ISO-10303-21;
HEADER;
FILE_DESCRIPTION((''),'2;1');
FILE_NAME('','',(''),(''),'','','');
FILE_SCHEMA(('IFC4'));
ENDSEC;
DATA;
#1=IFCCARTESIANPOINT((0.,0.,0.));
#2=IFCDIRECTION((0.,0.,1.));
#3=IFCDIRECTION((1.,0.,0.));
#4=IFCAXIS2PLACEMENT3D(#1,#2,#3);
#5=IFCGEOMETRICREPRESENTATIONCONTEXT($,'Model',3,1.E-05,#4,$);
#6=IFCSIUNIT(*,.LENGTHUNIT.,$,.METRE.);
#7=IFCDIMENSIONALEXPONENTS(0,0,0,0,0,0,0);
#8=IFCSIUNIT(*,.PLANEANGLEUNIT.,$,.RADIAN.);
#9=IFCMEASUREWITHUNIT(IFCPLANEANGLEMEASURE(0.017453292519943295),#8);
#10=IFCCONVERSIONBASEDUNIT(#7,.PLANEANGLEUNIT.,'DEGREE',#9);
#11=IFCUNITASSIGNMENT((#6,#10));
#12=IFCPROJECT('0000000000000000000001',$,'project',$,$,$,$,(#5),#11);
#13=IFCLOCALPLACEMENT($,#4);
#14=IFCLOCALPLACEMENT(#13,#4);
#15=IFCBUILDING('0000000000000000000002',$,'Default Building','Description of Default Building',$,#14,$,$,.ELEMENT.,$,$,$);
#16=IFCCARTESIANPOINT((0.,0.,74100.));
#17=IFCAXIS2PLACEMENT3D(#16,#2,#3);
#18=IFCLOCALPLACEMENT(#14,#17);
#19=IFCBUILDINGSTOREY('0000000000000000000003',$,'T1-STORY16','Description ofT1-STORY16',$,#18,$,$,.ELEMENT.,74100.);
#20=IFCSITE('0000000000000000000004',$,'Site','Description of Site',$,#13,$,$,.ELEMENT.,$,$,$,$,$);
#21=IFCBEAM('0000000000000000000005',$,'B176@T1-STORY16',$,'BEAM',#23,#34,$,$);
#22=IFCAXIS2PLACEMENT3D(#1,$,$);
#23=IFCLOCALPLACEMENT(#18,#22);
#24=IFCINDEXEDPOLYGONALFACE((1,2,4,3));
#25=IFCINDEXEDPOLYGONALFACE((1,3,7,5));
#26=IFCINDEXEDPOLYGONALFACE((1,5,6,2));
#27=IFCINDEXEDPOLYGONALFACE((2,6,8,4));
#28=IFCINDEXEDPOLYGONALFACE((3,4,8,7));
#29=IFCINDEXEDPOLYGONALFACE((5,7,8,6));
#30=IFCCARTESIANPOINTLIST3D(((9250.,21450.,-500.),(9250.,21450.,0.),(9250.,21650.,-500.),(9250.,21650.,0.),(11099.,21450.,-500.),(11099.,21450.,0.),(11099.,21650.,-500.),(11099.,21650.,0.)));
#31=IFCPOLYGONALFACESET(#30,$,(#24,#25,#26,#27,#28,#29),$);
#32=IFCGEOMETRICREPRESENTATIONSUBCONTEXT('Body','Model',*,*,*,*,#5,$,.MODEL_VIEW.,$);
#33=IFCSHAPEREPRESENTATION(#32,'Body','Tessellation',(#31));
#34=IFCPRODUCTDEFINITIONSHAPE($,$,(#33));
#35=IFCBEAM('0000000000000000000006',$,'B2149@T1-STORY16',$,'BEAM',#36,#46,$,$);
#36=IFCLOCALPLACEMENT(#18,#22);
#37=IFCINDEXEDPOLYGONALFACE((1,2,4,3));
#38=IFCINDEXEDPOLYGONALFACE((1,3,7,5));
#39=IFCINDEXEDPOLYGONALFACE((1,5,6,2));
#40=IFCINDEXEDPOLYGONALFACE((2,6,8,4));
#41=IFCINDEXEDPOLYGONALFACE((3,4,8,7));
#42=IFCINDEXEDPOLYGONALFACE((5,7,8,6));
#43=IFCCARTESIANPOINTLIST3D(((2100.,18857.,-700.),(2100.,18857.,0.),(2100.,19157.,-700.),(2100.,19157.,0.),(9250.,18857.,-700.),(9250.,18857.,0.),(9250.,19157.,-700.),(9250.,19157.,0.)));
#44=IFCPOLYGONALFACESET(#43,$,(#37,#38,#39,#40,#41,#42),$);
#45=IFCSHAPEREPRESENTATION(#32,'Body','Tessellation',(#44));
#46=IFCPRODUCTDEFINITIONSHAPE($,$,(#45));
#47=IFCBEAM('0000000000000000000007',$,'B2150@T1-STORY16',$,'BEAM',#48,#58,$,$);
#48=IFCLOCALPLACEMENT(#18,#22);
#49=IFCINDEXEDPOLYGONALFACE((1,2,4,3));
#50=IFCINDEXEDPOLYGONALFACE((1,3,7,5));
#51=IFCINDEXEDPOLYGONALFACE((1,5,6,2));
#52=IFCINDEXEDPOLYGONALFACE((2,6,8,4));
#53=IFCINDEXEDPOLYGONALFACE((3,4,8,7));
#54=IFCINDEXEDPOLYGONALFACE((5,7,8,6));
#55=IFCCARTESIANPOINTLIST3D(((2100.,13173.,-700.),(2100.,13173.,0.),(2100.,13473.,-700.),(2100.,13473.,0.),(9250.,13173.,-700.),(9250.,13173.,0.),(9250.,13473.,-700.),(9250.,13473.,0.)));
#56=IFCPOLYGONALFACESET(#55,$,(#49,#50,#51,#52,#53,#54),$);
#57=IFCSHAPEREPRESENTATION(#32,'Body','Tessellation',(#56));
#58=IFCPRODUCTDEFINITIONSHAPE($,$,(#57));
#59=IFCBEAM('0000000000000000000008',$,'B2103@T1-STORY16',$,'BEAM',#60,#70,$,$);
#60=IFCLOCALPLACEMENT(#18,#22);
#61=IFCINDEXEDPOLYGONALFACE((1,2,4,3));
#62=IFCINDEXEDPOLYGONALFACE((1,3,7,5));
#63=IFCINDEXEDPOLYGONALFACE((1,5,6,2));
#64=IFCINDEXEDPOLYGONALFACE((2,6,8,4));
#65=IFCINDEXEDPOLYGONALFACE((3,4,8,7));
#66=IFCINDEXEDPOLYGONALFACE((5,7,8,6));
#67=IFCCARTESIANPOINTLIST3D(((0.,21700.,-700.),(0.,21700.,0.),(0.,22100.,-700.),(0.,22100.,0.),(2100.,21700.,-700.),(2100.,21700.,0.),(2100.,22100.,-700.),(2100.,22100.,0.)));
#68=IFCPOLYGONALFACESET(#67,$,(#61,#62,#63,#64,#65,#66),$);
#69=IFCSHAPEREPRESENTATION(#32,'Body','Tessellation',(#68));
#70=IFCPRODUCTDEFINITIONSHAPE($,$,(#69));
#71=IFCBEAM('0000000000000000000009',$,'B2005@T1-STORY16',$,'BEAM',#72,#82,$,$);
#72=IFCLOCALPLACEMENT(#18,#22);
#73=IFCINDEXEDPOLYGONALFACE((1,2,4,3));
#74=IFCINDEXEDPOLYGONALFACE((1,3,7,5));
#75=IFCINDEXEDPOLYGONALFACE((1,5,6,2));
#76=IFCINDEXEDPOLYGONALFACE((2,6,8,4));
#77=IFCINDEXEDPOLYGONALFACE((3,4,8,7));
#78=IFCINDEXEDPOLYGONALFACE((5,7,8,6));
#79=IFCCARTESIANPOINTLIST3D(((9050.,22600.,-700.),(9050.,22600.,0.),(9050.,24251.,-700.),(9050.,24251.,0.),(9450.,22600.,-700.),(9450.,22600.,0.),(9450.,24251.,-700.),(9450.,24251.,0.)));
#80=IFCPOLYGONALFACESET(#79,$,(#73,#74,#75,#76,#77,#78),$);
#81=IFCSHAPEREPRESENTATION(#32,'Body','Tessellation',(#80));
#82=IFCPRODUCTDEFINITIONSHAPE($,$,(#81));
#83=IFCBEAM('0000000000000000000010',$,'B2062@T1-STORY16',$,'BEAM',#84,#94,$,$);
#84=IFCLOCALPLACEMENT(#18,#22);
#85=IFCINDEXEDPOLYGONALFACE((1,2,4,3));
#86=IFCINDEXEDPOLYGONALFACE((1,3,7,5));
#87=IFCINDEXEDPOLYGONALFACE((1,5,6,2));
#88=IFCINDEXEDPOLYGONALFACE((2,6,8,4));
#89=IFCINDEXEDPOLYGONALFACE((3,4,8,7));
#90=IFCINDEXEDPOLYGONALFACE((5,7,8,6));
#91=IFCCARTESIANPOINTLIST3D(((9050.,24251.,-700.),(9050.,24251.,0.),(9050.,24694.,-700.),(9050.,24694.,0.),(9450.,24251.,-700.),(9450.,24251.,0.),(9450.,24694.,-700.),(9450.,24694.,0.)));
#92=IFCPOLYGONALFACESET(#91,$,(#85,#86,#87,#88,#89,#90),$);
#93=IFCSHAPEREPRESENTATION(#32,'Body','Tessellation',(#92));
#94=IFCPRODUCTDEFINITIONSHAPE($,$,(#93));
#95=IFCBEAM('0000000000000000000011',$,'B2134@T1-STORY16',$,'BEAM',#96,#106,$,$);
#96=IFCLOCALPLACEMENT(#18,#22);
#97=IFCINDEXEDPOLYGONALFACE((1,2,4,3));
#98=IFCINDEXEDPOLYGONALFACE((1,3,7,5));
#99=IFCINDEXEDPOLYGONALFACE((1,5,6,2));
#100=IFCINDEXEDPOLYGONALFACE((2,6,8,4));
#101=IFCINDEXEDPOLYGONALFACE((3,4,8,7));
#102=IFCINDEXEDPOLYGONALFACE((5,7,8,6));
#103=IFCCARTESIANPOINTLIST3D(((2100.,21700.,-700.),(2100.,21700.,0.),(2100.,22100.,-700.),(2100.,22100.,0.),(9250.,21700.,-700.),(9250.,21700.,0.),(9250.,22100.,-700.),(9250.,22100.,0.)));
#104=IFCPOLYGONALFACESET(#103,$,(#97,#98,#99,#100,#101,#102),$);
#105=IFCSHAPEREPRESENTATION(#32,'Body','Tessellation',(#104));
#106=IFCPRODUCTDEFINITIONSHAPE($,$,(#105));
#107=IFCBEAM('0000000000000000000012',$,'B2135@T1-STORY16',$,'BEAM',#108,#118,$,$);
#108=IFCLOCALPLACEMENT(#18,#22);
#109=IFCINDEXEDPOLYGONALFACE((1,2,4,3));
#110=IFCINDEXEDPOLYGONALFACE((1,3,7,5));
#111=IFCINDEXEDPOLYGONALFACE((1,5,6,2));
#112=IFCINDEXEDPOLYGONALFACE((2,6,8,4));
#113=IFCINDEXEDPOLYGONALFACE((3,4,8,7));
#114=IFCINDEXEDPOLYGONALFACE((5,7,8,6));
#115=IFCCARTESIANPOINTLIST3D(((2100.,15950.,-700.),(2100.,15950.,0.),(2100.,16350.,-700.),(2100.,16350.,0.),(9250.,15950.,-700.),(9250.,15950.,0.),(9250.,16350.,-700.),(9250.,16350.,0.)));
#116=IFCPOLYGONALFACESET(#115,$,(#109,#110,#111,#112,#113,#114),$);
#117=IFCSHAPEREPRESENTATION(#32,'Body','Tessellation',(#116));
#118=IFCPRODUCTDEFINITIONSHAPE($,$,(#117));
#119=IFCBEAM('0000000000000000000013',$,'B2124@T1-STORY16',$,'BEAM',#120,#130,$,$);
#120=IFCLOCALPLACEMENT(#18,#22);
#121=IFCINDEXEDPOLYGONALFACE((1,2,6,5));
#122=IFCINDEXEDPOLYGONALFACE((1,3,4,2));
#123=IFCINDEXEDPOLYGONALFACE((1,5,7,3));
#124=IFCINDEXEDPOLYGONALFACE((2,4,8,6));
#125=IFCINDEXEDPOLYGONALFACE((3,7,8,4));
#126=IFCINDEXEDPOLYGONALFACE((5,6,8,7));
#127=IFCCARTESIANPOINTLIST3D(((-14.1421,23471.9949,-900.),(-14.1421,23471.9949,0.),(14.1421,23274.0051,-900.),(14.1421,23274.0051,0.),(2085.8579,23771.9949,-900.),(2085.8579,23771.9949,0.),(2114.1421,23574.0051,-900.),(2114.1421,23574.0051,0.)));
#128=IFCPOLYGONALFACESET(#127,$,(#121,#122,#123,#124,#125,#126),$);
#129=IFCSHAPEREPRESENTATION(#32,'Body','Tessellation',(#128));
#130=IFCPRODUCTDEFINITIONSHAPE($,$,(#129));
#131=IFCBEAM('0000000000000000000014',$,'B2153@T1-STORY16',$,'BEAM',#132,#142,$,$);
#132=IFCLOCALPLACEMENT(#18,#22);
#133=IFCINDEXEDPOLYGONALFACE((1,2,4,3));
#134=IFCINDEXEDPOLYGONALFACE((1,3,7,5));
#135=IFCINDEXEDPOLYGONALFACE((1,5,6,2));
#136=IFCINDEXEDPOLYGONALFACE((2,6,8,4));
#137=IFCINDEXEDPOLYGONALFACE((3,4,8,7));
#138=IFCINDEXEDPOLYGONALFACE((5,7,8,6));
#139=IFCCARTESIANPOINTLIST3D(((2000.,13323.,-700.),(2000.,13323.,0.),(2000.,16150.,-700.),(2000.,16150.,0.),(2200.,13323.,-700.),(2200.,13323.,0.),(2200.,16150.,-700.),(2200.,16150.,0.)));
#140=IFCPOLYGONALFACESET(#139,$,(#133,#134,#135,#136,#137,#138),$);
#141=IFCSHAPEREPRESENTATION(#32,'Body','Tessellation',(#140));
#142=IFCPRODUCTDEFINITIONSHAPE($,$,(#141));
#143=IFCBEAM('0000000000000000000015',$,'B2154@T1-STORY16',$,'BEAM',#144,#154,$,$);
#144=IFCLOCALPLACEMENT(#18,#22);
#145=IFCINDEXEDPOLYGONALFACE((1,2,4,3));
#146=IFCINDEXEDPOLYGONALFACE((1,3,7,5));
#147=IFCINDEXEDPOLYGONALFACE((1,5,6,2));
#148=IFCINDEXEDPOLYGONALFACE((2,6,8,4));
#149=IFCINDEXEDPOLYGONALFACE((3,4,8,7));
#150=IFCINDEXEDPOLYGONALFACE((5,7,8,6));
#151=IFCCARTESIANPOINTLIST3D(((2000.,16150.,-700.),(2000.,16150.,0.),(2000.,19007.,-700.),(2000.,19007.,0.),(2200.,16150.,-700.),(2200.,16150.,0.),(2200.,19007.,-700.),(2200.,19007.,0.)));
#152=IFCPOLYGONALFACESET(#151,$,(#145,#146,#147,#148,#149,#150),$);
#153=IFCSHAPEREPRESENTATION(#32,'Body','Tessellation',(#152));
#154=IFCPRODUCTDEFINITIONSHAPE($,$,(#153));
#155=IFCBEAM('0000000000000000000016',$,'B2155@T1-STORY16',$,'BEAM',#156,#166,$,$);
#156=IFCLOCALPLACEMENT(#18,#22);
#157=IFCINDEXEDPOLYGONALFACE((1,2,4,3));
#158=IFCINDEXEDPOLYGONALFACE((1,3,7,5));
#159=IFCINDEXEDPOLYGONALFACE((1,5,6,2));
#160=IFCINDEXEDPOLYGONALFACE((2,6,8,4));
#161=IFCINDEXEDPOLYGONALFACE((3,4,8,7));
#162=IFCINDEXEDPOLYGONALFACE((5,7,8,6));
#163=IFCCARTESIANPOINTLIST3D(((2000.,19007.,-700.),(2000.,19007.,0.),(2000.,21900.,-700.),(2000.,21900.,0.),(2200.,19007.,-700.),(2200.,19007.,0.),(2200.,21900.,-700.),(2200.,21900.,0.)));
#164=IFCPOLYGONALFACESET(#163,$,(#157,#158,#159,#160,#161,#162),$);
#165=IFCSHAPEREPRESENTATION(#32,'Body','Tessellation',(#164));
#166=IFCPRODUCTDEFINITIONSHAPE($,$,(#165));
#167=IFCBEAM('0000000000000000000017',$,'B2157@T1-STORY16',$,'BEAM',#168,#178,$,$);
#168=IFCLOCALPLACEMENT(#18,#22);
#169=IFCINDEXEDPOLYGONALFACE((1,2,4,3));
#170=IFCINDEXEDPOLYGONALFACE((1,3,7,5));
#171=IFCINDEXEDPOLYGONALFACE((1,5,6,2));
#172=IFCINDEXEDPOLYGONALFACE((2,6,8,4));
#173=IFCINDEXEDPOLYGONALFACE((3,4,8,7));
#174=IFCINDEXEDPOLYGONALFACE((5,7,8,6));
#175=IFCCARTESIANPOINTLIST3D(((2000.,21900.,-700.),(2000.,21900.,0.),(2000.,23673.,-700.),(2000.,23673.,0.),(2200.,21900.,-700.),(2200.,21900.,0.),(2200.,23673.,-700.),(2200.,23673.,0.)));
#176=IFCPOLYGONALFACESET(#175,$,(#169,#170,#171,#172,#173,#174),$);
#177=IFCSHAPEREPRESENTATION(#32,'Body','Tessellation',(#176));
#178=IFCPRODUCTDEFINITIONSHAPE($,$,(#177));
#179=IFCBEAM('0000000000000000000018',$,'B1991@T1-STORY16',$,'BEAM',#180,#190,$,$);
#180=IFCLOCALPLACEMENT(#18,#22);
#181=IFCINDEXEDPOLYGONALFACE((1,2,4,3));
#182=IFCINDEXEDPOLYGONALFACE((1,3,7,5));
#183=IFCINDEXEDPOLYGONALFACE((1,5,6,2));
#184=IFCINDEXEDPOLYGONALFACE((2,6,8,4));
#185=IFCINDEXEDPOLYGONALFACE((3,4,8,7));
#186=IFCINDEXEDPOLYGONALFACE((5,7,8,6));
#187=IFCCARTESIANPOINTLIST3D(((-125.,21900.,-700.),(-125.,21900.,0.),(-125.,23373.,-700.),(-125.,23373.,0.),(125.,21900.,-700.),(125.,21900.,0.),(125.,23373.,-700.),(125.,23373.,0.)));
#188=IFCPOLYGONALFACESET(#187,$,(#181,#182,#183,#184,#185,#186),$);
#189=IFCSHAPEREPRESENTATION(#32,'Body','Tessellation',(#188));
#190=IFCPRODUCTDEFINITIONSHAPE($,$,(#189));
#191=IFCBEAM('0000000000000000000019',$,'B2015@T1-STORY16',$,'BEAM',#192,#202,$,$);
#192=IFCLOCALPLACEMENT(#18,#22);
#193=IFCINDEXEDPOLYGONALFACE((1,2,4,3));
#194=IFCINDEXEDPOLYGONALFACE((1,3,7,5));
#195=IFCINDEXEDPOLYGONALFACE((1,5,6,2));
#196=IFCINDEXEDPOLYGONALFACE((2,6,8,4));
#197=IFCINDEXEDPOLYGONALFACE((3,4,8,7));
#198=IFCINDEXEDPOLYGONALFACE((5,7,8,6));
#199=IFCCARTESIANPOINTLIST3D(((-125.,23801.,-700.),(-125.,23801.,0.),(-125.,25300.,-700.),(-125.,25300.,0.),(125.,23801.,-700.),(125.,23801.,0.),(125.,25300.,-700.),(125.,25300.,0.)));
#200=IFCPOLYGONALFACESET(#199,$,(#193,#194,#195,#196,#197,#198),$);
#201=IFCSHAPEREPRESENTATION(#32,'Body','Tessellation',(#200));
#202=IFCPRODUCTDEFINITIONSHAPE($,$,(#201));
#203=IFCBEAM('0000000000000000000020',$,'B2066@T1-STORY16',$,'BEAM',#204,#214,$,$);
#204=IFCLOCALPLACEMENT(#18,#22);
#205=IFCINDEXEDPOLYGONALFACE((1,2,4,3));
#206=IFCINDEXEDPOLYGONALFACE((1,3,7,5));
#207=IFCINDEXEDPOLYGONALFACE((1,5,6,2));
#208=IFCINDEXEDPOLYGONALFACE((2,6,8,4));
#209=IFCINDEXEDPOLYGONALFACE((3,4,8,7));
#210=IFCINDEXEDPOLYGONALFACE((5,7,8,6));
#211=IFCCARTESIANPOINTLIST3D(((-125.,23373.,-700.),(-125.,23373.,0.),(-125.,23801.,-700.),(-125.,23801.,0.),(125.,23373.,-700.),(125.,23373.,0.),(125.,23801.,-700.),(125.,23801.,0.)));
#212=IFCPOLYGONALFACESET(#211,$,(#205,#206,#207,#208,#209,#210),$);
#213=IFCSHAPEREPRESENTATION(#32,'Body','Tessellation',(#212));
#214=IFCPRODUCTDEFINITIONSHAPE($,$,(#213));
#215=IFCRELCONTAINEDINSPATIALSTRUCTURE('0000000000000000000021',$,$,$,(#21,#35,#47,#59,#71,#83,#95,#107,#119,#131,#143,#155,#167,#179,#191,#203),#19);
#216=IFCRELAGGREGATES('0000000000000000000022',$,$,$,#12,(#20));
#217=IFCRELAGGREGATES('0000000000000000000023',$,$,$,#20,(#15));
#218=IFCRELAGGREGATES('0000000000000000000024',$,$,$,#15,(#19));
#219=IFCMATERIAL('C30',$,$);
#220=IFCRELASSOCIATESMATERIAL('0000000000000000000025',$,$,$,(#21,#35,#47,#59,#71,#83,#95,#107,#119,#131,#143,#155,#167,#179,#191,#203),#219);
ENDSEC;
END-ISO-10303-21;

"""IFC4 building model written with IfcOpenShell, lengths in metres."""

from ifc_helpers import new_model, entity, si_unit, converted_unit, frame, origin_with_axes, place, context, subcontext, project, spatial, rectangle, extrude, material, element, save


model = new_model("IFC4")

# Units and contexts
model_context = context("Model", 3, precision=1e-05, world=origin_with_axes())
body_context = subcontext(model_context, "Body", "Model", "MODEL_VIEW")
ifc_project = project(units=[si_unit("LENGTHUNIT", "METRE"), converted_unit("PLANEANGLEUNIT", "DEGREE", entity("IfcPlaneAngleMeasure", 0.017453292519943295), si_unit("PLANEANGLEUNIT", "RADIAN"), dimensions=[0, 0, 0, 0, 0, 0, 0])], contexts=[model_context])

# Site, building, storey
site_placement = place(None, origin_with_axes())
site = spatial("IfcSite", under=ifc_project, at=site_placement, Name="Site", Description="Description of Site", CompositionType="ELEMENT")
building_placement = place(site_placement, origin_with_axes())
building = spatial("IfcBuilding", under=site, at=building_placement, Name="Default Building", Description="Description of Default Building", CompositionType="ELEMENT")
storey_placement = place(building_placement, frame((0.0, 0.0, 74100.0), z_axis=(0.0, 0.0, 1.0), x_axis=(1.0, 0.0, 0.0)))
storey = spatial("IfcBuildingStorey", under=building, at=storey_placement, Name="T1-STORY16", Description="Description ofT1-STORY16", CompositionType="ELEMENT", Elevation=74100.0)

# Beams
ifc_material_1 = material(Name="C30")
beam_1_placement = place(storey_placement, frame((9250.0, 21550.0, -250.0), z_axis=(1.0, 0.0, 0.0), x_axis=(0.0, 1.0, 0.0)))
element("IfcBeam", 1, at=beam_1_placement, inside=storey, material=ifc_material_1, Name="B176@T1-STORY16", ObjectType="BEAM", context=body_context, shape_type="SweptSolid", body=[
    extrude(rectangle(XDim=200.0, YDim=500.0), origin_with_axes(), (0.0, 0.0, 1.0), 1849.0),
])
for number, where, z_axis, x_axis, name in (
    (2, (2100.0, 19007.0, -350.0), (1.0, 0.0, 0.0), (0.0, 1.0, 0.0), "B2149@T1-STORY16"),
    (3, (2100.0, 13323.0, -350.0), (1.0, 0.0, 0.0), (0.0, 1.0, 0.0), "B2150@T1-STORY16"),
):
    element("IfcBeam", number, at=place(storey_placement, frame(where, z_axis=z_axis, x_axis=x_axis)), inside=storey, material=ifc_material_1, Name=name, ObjectType="BEAM", context=body_context, shape_type="SweptSolid", body=[
        extrude(rectangle(XDim=300.0, YDim=700.0), origin_with_axes(), (0.0, 0.0, 1.0), 7150.0),
    ])
beam_2_placement = place(storey_placement, frame((0.0, 21900.0, -350.0), z_axis=(1.0, 0.0, 0.0), x_axis=(0.0, 1.0, 0.0)))
element("IfcBeam", 4, at=beam_2_placement, inside=storey, material=ifc_material_1, Name="B2103@T1-STORY16", ObjectType="BEAM", context=body_context, shape_type="SweptSolid", body=[
    extrude(rectangle(XDim=400.0, YDim=700.0), origin_with_axes(), (0.0, 0.0, 1.0), 2100.0),
])
beam_3_placement = place(storey_placement, frame((9250.0, 22600.0, -350.0), z_axis=(0.0, 1.0, 0.0), x_axis=(-1.0, 0.0, 0.0)))
element("IfcBeam", 5, at=beam_3_placement, inside=storey, material=ifc_material_1, Name="B2005@T1-STORY16", ObjectType="BEAM", context=body_context, shape_type="SweptSolid", body=[
    extrude(rectangle(XDim=400.0, YDim=700.0), origin_with_axes(), (0.0, 0.0, 1.0), 1651.0),
])
beam_4_placement = place(storey_placement, frame((9250.0, 24251.0, -350.0), z_axis=(0.0, 1.0, 0.0), x_axis=(-1.0, 0.0, 0.0)))
element("IfcBeam", 6, at=beam_4_placement, inside=storey, material=ifc_material_1, Name="B2062@T1-STORY16", ObjectType="BEAM", context=body_context, shape_type="SweptSolid", body=[
    extrude(rectangle(XDim=400.0, YDim=700.0), origin_with_axes(), (0.0, 0.0, 1.0), 443.0),
])
for number, where, z_axis, x_axis, name in (
    (7, (2100.0, 21900.0, -350.0), (1.0, 0.0, 0.0), (0.0, 1.0, 0.0), "B2134@T1-STORY16"),
    (8, (2100.0, 16150.0, -350.0), (1.0, 0.0, 0.0), (0.0, 1.0, 0.0), "B2135@T1-STORY16"),
):
    element("IfcBeam", number, at=place(storey_placement, frame(where, z_axis=z_axis, x_axis=x_axis)), inside=storey, material=ifc_material_1, Name=name, ObjectType="BEAM", context=body_context, shape_type="SweptSolid", body=[
        extrude(rectangle(XDim=400.0, YDim=700.0), origin_with_axes(), (0.0, 0.0, 1.0), 7150.0),
    ])
beam_5_placement = place(storey_placement, frame((0.0, 23373.0, -450.0), z_axis=(0.989949, 0.141421, 0.0), x_axis=(-0.141421, 0.989949, 0.0)))
element("IfcBeam", 9, at=beam_5_placement, inside=storey, material=ifc_material_1, Name="B2124@T1-STORY16", ObjectType="BEAM", context=body_context, shape_type="SweptSolid", body=[
    extrude(rectangle(XDim=200.0, YDim=900.0), origin_with_axes(), (0.0, 0.0, 1.0), 2121.3203),
])
beam_6_placement = place(storey_placement, frame((2100.0, 13323.0, -350.0), z_axis=(0.0, 1.0, 0.0), x_axis=(-1.0, 0.0, 0.0)))
element("IfcBeam", 10, at=beam_6_placement, inside=storey, material=ifc_material_1, Name="B2153@T1-STORY16", ObjectType="BEAM", context=body_context, shape_type="SweptSolid", body=[
    extrude(rectangle(XDim=200.0, YDim=700.0), origin_with_axes(), (0.0, 0.0, 1.0), 2827.0),
])
beam_7_placement = place(storey_placement, frame((2100.0, 16150.0, -350.0), z_axis=(0.0, 1.0, 0.0), x_axis=(-1.0, 0.0, 0.0)))
element("IfcBeam", 11, at=beam_7_placement, inside=storey, material=ifc_material_1, Name="B2154@T1-STORY16", ObjectType="BEAM", context=body_context, shape_type="SweptSolid", body=[
    extrude(rectangle(XDim=200.0, YDim=700.0), origin_with_axes(), (0.0, 0.0, 1.0), 2857.0),
])
beam_8_placement = place(storey_placement, frame((2100.0, 19007.0, -350.0), z_axis=(0.0, 1.0, 0.0), x_axis=(-1.0, 0.0, 0.0)))
element("IfcBeam", 12, at=beam_8_placement, inside=storey, material=ifc_material_1, Name="B2155@T1-STORY16", ObjectType="BEAM", context=body_context, shape_type="SweptSolid", body=[
    extrude(rectangle(XDim=200.0, YDim=700.0), origin_with_axes(), (0.0, 0.0, 1.0), 2893.0),
])
beam_9_placement = place(storey_placement, frame((2100.0, 21900.0, -350.0), z_axis=(0.0, 1.0, 0.0), x_axis=(-1.0, 0.0, 0.0)))
element("IfcBeam", 13, at=beam_9_placement, inside=storey, material=ifc_material_1, Name="B2157@T1-STORY16", ObjectType="BEAM", context=body_context, shape_type="SweptSolid", body=[
    extrude(rectangle(XDim=200.0, YDim=700.0), origin_with_axes(), (0.0, 0.0, 1.0), 1773.0),
])
beam_10_placement = place(storey_placement, frame((0.0, 21900.0, -350.0), z_axis=(0.0, 1.0, 0.0), x_axis=(-1.0, 0.0, 0.0)))
element("IfcBeam", 14, at=beam_10_placement, inside=storey, material=ifc_material_1, Name="B1991@T1-STORY16", ObjectType="BEAM", context=body_context, shape_type="SweptSolid", body=[
    extrude(rectangle(XDim=250.0, YDim=700.0), origin_with_axes(), (0.0, 0.0, 1.0), 1473.0),
])
beam_11_placement = place(storey_placement, frame((0.0, 23801.0, -350.0), z_axis=(0.0, 1.0, 0.0), x_axis=(-1.0, 0.0, 0.0)))
element("IfcBeam", 15, at=beam_11_placement, inside=storey, material=ifc_material_1, Name="B2015@T1-STORY16", ObjectType="BEAM", context=body_context, shape_type="SweptSolid", body=[
    extrude(rectangle(XDim=250.0, YDim=700.0), origin_with_axes(), (0.0, 0.0, 1.0), 1499.0),
])
beam_12_placement = place(storey_placement, frame((0.0, 23373.0, -350.0), z_axis=(0.0, 1.0, 0.0), x_axis=(-1.0, 0.0, 0.0)))
element("IfcBeam", 16, at=beam_12_placement, inside=storey, material=ifc_material_1, Name="B2066@T1-STORY16", ObjectType="BEAM", context=body_context, shape_type="SweptSolid", body=[
    extrude(rectangle(XDim=250.0, YDim=700.0), origin_with_axes(), (0.0, 0.0, 1.0), 428.0),
])

save(model, "model.ifc")
